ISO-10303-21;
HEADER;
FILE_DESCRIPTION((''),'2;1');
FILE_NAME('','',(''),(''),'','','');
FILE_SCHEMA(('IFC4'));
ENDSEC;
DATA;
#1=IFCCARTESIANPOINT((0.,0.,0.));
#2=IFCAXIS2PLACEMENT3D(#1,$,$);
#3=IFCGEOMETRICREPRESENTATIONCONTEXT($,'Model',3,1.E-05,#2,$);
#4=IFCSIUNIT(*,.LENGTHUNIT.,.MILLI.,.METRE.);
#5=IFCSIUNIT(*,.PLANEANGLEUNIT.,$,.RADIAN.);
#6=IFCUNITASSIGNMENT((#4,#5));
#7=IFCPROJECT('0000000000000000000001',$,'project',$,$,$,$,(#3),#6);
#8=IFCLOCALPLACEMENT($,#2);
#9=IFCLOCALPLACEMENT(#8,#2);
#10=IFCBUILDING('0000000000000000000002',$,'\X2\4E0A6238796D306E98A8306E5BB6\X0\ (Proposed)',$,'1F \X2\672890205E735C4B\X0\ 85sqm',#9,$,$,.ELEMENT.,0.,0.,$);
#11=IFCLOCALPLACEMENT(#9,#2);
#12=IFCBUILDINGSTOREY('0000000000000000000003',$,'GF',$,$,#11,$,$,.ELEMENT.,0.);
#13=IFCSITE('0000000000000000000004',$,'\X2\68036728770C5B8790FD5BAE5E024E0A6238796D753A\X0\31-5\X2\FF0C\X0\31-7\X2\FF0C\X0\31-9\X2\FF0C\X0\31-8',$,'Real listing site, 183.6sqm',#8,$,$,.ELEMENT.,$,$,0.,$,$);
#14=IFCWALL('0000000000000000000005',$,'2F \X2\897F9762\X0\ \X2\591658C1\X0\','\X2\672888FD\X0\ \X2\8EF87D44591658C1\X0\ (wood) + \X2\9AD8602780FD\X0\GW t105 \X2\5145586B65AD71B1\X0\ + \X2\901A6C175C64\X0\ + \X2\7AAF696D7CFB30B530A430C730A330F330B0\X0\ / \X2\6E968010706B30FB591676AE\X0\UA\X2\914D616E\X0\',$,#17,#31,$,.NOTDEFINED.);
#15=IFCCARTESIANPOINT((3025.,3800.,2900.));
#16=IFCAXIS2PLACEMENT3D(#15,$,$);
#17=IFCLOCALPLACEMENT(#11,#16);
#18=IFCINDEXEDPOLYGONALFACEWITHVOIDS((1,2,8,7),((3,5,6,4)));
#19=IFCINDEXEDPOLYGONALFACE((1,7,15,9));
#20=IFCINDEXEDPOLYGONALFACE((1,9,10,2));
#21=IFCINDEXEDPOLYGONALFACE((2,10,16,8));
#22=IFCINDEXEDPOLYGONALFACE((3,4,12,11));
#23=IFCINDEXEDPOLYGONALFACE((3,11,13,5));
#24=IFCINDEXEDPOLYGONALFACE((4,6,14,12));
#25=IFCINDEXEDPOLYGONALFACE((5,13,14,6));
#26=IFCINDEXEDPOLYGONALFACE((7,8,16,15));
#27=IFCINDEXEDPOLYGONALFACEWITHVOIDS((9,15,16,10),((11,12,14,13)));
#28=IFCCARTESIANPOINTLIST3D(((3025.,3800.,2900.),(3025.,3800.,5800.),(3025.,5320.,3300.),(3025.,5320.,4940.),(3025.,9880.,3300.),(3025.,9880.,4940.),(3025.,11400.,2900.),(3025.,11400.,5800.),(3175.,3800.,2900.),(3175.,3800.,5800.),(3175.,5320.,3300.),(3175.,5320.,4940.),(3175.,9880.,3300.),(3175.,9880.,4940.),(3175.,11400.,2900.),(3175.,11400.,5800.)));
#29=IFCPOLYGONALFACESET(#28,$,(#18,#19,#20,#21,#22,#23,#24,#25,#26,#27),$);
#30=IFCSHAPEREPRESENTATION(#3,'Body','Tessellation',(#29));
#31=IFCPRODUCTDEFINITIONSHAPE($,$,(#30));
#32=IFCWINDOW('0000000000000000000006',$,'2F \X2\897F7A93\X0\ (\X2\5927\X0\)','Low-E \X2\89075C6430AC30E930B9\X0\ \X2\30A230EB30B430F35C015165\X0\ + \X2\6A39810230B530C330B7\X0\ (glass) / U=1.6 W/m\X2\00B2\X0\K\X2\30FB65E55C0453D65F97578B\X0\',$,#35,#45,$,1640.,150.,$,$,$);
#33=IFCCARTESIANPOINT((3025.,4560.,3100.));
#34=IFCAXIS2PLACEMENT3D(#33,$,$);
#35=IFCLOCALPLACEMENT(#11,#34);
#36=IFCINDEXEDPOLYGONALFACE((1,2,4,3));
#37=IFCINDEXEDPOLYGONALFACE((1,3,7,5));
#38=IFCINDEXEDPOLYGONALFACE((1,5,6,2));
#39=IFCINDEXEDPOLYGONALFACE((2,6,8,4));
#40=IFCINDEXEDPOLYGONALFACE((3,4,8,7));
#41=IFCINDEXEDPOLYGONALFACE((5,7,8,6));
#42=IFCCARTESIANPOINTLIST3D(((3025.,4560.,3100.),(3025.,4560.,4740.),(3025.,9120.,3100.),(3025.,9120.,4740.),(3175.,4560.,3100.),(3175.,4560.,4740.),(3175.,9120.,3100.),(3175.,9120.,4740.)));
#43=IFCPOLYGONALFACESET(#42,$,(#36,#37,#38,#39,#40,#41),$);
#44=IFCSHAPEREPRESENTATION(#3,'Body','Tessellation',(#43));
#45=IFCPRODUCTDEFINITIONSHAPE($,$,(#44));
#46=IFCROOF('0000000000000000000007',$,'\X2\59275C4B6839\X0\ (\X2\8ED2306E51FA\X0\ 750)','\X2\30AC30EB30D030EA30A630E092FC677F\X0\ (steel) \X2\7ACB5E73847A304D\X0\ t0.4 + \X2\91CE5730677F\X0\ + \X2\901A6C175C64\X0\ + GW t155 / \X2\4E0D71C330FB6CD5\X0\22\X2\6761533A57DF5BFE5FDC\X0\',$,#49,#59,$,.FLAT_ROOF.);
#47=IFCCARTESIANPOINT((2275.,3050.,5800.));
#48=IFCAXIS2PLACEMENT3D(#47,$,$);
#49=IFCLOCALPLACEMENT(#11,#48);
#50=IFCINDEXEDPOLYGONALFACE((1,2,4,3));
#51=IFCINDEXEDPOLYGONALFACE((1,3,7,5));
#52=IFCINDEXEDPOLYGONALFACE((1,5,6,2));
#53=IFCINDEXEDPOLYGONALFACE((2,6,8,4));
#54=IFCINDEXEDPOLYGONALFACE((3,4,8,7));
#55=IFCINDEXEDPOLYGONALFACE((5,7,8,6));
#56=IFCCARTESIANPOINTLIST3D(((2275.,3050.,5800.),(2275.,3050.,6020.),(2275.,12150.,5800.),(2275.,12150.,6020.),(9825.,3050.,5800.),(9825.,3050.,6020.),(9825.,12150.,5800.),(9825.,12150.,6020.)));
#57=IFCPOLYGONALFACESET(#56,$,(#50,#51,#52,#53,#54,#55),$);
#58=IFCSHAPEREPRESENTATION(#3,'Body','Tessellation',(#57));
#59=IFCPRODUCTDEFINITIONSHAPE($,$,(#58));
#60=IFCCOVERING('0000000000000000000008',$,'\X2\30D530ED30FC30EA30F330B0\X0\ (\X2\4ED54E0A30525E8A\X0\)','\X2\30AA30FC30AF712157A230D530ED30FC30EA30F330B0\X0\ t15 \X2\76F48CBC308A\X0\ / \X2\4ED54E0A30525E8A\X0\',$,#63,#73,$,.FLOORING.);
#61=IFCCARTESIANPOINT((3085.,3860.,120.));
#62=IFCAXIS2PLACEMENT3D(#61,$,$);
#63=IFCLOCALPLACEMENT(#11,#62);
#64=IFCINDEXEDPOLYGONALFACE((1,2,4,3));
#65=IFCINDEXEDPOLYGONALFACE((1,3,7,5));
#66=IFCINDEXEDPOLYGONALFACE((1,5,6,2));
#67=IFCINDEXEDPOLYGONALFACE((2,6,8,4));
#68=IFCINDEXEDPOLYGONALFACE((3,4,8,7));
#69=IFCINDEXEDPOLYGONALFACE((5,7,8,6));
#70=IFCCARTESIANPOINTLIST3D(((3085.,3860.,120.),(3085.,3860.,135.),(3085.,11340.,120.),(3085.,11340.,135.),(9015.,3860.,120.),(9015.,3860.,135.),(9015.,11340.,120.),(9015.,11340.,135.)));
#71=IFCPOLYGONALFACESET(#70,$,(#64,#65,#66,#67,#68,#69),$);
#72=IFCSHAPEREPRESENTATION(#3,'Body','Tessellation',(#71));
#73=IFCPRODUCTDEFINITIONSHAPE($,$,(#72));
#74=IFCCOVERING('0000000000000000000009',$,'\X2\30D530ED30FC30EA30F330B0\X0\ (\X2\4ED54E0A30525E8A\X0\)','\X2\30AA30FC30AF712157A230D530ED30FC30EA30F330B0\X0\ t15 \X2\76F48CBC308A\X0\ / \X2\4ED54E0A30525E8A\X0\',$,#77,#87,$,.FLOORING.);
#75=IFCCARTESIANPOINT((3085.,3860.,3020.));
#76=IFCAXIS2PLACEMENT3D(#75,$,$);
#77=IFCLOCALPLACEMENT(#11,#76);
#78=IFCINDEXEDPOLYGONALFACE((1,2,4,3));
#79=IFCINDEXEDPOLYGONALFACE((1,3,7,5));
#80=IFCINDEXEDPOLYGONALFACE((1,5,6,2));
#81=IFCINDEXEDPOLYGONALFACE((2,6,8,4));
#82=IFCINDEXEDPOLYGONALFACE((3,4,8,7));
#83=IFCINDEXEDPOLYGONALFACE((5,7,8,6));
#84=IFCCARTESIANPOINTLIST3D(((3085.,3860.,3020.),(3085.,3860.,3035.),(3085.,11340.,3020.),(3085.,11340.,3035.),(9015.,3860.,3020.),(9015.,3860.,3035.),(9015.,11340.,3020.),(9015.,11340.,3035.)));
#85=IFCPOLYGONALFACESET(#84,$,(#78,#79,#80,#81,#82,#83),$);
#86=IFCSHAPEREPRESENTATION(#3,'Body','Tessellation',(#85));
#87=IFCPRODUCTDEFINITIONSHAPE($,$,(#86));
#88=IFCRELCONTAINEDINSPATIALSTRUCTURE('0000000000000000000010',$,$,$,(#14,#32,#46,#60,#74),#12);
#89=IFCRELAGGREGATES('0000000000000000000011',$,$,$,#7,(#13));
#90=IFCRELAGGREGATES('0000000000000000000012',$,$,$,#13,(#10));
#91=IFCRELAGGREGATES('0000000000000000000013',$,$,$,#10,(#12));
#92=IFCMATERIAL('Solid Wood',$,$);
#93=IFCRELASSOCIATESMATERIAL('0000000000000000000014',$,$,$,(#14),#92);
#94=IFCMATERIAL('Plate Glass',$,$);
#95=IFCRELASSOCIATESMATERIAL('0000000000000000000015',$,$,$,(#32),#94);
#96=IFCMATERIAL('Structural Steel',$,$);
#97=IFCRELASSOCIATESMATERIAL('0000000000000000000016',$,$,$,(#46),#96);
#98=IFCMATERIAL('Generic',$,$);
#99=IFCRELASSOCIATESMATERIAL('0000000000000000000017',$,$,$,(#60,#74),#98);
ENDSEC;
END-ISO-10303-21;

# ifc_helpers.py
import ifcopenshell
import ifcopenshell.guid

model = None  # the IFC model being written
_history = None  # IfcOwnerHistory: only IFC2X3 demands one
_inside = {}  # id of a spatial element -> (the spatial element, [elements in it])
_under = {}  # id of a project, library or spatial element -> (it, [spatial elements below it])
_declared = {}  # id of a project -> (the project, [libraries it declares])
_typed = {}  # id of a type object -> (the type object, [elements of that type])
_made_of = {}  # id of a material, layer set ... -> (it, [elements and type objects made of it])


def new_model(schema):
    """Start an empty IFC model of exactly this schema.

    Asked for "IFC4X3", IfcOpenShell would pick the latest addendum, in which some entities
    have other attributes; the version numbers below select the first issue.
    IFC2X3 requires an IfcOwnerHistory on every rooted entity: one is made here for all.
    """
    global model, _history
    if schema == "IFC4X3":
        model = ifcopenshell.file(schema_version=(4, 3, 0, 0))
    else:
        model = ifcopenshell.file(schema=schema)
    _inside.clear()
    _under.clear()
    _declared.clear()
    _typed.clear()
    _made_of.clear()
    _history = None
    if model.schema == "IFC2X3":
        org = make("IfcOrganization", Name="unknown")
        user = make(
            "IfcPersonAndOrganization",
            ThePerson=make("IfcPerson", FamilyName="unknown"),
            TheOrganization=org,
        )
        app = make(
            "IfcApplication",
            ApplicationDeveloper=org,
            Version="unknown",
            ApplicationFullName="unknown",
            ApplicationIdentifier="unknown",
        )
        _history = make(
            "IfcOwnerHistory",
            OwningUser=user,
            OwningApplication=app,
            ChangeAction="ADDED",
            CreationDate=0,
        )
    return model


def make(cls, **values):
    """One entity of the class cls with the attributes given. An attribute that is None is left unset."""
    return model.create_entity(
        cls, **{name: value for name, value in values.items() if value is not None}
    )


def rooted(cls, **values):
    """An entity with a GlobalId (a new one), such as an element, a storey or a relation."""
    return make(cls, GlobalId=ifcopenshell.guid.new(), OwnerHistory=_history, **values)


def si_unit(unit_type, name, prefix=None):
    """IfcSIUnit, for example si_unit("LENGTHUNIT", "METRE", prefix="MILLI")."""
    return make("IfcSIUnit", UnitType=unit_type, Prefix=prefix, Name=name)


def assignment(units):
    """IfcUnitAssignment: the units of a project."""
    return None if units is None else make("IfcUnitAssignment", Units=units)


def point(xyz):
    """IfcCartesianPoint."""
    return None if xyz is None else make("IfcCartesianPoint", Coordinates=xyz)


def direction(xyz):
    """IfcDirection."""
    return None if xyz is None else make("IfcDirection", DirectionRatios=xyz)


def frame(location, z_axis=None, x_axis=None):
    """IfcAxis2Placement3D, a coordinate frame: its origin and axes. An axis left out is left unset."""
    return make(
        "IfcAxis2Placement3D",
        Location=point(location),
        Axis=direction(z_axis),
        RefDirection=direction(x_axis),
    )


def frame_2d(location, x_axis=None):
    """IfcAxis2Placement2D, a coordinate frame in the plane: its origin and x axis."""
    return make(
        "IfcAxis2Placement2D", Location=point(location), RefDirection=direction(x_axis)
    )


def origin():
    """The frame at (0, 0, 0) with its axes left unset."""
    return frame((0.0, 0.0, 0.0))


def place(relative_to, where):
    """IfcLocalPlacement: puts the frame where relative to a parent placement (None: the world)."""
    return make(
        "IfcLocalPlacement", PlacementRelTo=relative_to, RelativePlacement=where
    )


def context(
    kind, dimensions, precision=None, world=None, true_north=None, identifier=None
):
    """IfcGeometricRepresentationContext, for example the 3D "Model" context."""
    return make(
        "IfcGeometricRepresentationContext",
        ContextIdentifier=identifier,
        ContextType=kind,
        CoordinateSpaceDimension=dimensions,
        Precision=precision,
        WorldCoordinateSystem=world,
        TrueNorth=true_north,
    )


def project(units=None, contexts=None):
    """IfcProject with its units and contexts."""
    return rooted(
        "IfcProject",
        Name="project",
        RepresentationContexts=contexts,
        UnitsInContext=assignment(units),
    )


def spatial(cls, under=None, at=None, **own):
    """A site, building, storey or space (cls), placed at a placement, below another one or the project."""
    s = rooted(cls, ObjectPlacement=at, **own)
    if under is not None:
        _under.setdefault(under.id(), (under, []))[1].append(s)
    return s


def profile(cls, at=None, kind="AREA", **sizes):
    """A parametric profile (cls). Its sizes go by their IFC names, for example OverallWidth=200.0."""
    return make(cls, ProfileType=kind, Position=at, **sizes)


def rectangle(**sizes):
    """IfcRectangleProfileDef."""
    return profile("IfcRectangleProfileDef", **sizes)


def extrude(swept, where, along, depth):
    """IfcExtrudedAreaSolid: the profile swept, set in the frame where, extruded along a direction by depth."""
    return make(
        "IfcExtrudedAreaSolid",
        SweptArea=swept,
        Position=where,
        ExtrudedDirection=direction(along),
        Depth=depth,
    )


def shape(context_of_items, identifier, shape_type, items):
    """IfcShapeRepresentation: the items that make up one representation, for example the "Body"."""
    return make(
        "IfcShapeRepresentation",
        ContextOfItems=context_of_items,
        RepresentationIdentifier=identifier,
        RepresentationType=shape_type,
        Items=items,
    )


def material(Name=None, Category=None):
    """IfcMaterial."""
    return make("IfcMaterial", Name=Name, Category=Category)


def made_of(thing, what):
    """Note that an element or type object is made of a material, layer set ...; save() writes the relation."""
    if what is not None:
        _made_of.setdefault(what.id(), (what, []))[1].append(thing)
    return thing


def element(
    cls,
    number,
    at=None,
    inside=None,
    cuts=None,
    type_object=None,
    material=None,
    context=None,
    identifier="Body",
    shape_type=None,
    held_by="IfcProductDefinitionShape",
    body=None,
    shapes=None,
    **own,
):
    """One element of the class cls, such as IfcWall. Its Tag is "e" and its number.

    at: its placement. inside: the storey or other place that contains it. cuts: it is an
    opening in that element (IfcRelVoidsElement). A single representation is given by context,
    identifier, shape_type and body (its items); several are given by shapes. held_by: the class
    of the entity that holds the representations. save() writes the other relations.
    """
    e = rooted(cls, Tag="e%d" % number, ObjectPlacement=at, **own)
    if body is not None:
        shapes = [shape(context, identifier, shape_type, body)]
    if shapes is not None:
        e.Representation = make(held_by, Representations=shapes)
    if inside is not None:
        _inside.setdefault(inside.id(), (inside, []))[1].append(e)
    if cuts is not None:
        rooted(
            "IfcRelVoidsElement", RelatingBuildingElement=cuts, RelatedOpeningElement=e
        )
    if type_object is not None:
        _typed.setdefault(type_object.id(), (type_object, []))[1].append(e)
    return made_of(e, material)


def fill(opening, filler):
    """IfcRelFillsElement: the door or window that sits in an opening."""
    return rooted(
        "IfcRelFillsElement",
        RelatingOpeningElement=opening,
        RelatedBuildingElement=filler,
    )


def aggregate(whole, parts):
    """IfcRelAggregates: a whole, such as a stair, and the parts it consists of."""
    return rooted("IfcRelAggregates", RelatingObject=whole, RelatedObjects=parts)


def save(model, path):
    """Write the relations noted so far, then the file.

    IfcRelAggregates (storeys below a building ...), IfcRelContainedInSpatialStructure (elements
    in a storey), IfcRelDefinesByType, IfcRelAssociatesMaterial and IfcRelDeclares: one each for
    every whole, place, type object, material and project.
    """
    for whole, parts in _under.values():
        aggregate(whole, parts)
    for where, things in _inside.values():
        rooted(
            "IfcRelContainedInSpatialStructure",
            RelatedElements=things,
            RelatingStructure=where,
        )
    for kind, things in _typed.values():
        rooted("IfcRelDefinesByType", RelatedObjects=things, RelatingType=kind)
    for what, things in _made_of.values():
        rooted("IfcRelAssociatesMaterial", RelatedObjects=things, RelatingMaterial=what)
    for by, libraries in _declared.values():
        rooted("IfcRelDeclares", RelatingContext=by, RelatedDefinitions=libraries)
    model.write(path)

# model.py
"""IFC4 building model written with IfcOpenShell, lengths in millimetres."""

from ifc_helpers import new_model, si_unit, frame, frame_2d, origin, place, context, project, spatial, rectangle, extrude, material, element, fill, save


model = new_model("IFC4")

# Units and contexts
model_context = context("Model", 3, precision=1e-05, world=origin())
ifc_project = project(units=[si_unit("LENGTHUNIT", "METRE", prefix="MILLI"), si_unit("PLANEANGLEUNIT", "RADIAN")], contexts=[model_context])

# Site, building, storey
site_placement = place(None, origin())
site = spatial("IfcSite", under=ifc_project, at=site_placement, Name="栃木県宇都宮市上戸祭町31-5，31-7，31-9，31-8", ObjectType="Real listing site, 183.6sqm", CompositionType="ELEMENT", RefElevation=0.0)
building_placement = place(site_placement, origin())
building = spatial("IfcBuilding", under=site, at=building_placement, Name="上戸祭の風の家 (Proposed)", ObjectType="1F 木造平屋 85sqm", CompositionType="ELEMENT", ElevationOfRefHeight=0.0, ElevationOfTerrain=0.0)
storey_placement = place(building_placement, origin())
storey = spatial("IfcBuildingStorey", under=building, at=storey_placement, Name="GF", CompositionType="ELEMENT", Elevation=0.0)

# Shared definitions
ifc_material_1 = material(Name="Solid Wood")
ifc_material_2 = material(Name="Generic")

# Shared definitions
ifc_material_3 = material(Name="Plate Glass")

# Wall, opening, window
wall_1_placement = place(storey_placement, frame((3025.0, 3800.0, 2900.0)))
wall_1 = element("IfcWall", 1, at=wall_1_placement, inside=storey, material=ifc_material_1, Name="2F 西面 外壁", Description="木製 軸組外壁 (wood) + 高性能GW t105 充填断熱 + 通気層 + 窯業系サイディング / 準耐火・外皮UA配慮", PredefinedType="NOTDEFINED", context=model_context, shape_type="SweptSolid", body=[
    extrude(rectangle(XDim=150.0, YDim=7600.0, at=frame_2d((75.0, 3800.0))), frame((3025.0, 3800.0, 2900.0)), (0.0, 0.0, 1.0), 2900.0),
])
opening_1_placement = place(storey_placement, frame((3025.0, 4560.0, 3100.0)))
opening_1 = element("IfcOpeningElement", 2, at=opening_1_placement, cuts=wall_1, PredefinedType="NOTDEFINED", context=model_context, shape_type="SweptSolid", body=[
    extrude(rectangle(XDim=150.0, YDim=4560.0, at=frame_2d((75.0, 2280.0))), frame((3025.0, 4560.0, 3100.0)), (0.0, 0.0, 1.0), 1640.0),
])
window_1_placement = place(storey_placement, frame((3025.0, 4560.0, 3100.0)))
window_1 = element("IfcWindow", 3, at=window_1_placement, inside=storey, material=ifc_material_3, Name="2F 西窓 (大)", Description="Low-E 複層ガラス アルゴン封入 + 樹脂サッシ (glass) / U=1.6 W/m²K・日射取得型", OverallHeight=1640.0, OverallWidth=150.0, context=model_context, shape_type="SweptSolid", body=[
    extrude(rectangle(XDim=150.0, YDim=4560.0, at=frame_2d((75.0, 2280.0))), frame((3025.0, 4560.0, 3100.0)), (0.0, 0.0, 1.0), 1640.0),
])
fill(opening_1, window_1)

# Roof
ifc_material_4 = material(Name="Structural Steel")
roof_placement = place(storey_placement, frame((2275.0, 3050.0, 5800.0)))
element("IfcRoof", 4, at=roof_placement, inside=storey, material=ifc_material_4, Name="大屋根 (軒の出 750)", Description="ガルバリウム鋼板 (steel) 立平葺き t0.4 + 野地板 + 通気層 + GW t155 / 不燃・法22条区域対応", PredefinedType="FLAT_ROOF", context=model_context, shape_type="SweptSolid", body=[
    extrude(rectangle(XDim=7550.0, YDim=9100.0, at=frame_2d((3775.0, 4550.0))), frame((2275.0, 3050.0, 5800.0)), (0.0, 0.0, 1.0), 220.0),
])

# Coverings
covering_1_placement = place(storey_placement, frame((3085.0, 3860.0, 120.0)))
element("IfcCovering", 5, at=covering_1_placement, inside=storey, material=ifc_material_2, Name="フローリング (仕上げ床)", Description="オーク無垢フローリング t15 直貼り / 仕上げ床", PredefinedType="FLOORING", context=model_context, shape_type="SweptSolid", body=[
    extrude(rectangle(XDim=5930.0, YDim=7480.0, at=frame_2d((2965.0, 3740.0))), frame((3085.0, 3860.0, 120.0)), (0.0, 0.0, 1.0), 15.0),
])
covering_2_placement = place(storey_placement, frame((3085.0, 3860.0, 3020.0)))
element("IfcCovering", 6, at=covering_2_placement, inside=storey, material=ifc_material_2, Name="フローリング (仕上げ床)", Description="オーク無垢フローリング t15 直貼り / 仕上げ床", PredefinedType="FLOORING", context=model_context, shape_type="SweptSolid", body=[
    extrude(rectangle(XDim=5930.0, YDim=7480.0, at=frame_2d((2965.0, 3740.0))), frame((3085.0, 3860.0, 3020.0)), (0.0, 0.0, 1.0), 15.0),
])

save(model, "model.ifc")
